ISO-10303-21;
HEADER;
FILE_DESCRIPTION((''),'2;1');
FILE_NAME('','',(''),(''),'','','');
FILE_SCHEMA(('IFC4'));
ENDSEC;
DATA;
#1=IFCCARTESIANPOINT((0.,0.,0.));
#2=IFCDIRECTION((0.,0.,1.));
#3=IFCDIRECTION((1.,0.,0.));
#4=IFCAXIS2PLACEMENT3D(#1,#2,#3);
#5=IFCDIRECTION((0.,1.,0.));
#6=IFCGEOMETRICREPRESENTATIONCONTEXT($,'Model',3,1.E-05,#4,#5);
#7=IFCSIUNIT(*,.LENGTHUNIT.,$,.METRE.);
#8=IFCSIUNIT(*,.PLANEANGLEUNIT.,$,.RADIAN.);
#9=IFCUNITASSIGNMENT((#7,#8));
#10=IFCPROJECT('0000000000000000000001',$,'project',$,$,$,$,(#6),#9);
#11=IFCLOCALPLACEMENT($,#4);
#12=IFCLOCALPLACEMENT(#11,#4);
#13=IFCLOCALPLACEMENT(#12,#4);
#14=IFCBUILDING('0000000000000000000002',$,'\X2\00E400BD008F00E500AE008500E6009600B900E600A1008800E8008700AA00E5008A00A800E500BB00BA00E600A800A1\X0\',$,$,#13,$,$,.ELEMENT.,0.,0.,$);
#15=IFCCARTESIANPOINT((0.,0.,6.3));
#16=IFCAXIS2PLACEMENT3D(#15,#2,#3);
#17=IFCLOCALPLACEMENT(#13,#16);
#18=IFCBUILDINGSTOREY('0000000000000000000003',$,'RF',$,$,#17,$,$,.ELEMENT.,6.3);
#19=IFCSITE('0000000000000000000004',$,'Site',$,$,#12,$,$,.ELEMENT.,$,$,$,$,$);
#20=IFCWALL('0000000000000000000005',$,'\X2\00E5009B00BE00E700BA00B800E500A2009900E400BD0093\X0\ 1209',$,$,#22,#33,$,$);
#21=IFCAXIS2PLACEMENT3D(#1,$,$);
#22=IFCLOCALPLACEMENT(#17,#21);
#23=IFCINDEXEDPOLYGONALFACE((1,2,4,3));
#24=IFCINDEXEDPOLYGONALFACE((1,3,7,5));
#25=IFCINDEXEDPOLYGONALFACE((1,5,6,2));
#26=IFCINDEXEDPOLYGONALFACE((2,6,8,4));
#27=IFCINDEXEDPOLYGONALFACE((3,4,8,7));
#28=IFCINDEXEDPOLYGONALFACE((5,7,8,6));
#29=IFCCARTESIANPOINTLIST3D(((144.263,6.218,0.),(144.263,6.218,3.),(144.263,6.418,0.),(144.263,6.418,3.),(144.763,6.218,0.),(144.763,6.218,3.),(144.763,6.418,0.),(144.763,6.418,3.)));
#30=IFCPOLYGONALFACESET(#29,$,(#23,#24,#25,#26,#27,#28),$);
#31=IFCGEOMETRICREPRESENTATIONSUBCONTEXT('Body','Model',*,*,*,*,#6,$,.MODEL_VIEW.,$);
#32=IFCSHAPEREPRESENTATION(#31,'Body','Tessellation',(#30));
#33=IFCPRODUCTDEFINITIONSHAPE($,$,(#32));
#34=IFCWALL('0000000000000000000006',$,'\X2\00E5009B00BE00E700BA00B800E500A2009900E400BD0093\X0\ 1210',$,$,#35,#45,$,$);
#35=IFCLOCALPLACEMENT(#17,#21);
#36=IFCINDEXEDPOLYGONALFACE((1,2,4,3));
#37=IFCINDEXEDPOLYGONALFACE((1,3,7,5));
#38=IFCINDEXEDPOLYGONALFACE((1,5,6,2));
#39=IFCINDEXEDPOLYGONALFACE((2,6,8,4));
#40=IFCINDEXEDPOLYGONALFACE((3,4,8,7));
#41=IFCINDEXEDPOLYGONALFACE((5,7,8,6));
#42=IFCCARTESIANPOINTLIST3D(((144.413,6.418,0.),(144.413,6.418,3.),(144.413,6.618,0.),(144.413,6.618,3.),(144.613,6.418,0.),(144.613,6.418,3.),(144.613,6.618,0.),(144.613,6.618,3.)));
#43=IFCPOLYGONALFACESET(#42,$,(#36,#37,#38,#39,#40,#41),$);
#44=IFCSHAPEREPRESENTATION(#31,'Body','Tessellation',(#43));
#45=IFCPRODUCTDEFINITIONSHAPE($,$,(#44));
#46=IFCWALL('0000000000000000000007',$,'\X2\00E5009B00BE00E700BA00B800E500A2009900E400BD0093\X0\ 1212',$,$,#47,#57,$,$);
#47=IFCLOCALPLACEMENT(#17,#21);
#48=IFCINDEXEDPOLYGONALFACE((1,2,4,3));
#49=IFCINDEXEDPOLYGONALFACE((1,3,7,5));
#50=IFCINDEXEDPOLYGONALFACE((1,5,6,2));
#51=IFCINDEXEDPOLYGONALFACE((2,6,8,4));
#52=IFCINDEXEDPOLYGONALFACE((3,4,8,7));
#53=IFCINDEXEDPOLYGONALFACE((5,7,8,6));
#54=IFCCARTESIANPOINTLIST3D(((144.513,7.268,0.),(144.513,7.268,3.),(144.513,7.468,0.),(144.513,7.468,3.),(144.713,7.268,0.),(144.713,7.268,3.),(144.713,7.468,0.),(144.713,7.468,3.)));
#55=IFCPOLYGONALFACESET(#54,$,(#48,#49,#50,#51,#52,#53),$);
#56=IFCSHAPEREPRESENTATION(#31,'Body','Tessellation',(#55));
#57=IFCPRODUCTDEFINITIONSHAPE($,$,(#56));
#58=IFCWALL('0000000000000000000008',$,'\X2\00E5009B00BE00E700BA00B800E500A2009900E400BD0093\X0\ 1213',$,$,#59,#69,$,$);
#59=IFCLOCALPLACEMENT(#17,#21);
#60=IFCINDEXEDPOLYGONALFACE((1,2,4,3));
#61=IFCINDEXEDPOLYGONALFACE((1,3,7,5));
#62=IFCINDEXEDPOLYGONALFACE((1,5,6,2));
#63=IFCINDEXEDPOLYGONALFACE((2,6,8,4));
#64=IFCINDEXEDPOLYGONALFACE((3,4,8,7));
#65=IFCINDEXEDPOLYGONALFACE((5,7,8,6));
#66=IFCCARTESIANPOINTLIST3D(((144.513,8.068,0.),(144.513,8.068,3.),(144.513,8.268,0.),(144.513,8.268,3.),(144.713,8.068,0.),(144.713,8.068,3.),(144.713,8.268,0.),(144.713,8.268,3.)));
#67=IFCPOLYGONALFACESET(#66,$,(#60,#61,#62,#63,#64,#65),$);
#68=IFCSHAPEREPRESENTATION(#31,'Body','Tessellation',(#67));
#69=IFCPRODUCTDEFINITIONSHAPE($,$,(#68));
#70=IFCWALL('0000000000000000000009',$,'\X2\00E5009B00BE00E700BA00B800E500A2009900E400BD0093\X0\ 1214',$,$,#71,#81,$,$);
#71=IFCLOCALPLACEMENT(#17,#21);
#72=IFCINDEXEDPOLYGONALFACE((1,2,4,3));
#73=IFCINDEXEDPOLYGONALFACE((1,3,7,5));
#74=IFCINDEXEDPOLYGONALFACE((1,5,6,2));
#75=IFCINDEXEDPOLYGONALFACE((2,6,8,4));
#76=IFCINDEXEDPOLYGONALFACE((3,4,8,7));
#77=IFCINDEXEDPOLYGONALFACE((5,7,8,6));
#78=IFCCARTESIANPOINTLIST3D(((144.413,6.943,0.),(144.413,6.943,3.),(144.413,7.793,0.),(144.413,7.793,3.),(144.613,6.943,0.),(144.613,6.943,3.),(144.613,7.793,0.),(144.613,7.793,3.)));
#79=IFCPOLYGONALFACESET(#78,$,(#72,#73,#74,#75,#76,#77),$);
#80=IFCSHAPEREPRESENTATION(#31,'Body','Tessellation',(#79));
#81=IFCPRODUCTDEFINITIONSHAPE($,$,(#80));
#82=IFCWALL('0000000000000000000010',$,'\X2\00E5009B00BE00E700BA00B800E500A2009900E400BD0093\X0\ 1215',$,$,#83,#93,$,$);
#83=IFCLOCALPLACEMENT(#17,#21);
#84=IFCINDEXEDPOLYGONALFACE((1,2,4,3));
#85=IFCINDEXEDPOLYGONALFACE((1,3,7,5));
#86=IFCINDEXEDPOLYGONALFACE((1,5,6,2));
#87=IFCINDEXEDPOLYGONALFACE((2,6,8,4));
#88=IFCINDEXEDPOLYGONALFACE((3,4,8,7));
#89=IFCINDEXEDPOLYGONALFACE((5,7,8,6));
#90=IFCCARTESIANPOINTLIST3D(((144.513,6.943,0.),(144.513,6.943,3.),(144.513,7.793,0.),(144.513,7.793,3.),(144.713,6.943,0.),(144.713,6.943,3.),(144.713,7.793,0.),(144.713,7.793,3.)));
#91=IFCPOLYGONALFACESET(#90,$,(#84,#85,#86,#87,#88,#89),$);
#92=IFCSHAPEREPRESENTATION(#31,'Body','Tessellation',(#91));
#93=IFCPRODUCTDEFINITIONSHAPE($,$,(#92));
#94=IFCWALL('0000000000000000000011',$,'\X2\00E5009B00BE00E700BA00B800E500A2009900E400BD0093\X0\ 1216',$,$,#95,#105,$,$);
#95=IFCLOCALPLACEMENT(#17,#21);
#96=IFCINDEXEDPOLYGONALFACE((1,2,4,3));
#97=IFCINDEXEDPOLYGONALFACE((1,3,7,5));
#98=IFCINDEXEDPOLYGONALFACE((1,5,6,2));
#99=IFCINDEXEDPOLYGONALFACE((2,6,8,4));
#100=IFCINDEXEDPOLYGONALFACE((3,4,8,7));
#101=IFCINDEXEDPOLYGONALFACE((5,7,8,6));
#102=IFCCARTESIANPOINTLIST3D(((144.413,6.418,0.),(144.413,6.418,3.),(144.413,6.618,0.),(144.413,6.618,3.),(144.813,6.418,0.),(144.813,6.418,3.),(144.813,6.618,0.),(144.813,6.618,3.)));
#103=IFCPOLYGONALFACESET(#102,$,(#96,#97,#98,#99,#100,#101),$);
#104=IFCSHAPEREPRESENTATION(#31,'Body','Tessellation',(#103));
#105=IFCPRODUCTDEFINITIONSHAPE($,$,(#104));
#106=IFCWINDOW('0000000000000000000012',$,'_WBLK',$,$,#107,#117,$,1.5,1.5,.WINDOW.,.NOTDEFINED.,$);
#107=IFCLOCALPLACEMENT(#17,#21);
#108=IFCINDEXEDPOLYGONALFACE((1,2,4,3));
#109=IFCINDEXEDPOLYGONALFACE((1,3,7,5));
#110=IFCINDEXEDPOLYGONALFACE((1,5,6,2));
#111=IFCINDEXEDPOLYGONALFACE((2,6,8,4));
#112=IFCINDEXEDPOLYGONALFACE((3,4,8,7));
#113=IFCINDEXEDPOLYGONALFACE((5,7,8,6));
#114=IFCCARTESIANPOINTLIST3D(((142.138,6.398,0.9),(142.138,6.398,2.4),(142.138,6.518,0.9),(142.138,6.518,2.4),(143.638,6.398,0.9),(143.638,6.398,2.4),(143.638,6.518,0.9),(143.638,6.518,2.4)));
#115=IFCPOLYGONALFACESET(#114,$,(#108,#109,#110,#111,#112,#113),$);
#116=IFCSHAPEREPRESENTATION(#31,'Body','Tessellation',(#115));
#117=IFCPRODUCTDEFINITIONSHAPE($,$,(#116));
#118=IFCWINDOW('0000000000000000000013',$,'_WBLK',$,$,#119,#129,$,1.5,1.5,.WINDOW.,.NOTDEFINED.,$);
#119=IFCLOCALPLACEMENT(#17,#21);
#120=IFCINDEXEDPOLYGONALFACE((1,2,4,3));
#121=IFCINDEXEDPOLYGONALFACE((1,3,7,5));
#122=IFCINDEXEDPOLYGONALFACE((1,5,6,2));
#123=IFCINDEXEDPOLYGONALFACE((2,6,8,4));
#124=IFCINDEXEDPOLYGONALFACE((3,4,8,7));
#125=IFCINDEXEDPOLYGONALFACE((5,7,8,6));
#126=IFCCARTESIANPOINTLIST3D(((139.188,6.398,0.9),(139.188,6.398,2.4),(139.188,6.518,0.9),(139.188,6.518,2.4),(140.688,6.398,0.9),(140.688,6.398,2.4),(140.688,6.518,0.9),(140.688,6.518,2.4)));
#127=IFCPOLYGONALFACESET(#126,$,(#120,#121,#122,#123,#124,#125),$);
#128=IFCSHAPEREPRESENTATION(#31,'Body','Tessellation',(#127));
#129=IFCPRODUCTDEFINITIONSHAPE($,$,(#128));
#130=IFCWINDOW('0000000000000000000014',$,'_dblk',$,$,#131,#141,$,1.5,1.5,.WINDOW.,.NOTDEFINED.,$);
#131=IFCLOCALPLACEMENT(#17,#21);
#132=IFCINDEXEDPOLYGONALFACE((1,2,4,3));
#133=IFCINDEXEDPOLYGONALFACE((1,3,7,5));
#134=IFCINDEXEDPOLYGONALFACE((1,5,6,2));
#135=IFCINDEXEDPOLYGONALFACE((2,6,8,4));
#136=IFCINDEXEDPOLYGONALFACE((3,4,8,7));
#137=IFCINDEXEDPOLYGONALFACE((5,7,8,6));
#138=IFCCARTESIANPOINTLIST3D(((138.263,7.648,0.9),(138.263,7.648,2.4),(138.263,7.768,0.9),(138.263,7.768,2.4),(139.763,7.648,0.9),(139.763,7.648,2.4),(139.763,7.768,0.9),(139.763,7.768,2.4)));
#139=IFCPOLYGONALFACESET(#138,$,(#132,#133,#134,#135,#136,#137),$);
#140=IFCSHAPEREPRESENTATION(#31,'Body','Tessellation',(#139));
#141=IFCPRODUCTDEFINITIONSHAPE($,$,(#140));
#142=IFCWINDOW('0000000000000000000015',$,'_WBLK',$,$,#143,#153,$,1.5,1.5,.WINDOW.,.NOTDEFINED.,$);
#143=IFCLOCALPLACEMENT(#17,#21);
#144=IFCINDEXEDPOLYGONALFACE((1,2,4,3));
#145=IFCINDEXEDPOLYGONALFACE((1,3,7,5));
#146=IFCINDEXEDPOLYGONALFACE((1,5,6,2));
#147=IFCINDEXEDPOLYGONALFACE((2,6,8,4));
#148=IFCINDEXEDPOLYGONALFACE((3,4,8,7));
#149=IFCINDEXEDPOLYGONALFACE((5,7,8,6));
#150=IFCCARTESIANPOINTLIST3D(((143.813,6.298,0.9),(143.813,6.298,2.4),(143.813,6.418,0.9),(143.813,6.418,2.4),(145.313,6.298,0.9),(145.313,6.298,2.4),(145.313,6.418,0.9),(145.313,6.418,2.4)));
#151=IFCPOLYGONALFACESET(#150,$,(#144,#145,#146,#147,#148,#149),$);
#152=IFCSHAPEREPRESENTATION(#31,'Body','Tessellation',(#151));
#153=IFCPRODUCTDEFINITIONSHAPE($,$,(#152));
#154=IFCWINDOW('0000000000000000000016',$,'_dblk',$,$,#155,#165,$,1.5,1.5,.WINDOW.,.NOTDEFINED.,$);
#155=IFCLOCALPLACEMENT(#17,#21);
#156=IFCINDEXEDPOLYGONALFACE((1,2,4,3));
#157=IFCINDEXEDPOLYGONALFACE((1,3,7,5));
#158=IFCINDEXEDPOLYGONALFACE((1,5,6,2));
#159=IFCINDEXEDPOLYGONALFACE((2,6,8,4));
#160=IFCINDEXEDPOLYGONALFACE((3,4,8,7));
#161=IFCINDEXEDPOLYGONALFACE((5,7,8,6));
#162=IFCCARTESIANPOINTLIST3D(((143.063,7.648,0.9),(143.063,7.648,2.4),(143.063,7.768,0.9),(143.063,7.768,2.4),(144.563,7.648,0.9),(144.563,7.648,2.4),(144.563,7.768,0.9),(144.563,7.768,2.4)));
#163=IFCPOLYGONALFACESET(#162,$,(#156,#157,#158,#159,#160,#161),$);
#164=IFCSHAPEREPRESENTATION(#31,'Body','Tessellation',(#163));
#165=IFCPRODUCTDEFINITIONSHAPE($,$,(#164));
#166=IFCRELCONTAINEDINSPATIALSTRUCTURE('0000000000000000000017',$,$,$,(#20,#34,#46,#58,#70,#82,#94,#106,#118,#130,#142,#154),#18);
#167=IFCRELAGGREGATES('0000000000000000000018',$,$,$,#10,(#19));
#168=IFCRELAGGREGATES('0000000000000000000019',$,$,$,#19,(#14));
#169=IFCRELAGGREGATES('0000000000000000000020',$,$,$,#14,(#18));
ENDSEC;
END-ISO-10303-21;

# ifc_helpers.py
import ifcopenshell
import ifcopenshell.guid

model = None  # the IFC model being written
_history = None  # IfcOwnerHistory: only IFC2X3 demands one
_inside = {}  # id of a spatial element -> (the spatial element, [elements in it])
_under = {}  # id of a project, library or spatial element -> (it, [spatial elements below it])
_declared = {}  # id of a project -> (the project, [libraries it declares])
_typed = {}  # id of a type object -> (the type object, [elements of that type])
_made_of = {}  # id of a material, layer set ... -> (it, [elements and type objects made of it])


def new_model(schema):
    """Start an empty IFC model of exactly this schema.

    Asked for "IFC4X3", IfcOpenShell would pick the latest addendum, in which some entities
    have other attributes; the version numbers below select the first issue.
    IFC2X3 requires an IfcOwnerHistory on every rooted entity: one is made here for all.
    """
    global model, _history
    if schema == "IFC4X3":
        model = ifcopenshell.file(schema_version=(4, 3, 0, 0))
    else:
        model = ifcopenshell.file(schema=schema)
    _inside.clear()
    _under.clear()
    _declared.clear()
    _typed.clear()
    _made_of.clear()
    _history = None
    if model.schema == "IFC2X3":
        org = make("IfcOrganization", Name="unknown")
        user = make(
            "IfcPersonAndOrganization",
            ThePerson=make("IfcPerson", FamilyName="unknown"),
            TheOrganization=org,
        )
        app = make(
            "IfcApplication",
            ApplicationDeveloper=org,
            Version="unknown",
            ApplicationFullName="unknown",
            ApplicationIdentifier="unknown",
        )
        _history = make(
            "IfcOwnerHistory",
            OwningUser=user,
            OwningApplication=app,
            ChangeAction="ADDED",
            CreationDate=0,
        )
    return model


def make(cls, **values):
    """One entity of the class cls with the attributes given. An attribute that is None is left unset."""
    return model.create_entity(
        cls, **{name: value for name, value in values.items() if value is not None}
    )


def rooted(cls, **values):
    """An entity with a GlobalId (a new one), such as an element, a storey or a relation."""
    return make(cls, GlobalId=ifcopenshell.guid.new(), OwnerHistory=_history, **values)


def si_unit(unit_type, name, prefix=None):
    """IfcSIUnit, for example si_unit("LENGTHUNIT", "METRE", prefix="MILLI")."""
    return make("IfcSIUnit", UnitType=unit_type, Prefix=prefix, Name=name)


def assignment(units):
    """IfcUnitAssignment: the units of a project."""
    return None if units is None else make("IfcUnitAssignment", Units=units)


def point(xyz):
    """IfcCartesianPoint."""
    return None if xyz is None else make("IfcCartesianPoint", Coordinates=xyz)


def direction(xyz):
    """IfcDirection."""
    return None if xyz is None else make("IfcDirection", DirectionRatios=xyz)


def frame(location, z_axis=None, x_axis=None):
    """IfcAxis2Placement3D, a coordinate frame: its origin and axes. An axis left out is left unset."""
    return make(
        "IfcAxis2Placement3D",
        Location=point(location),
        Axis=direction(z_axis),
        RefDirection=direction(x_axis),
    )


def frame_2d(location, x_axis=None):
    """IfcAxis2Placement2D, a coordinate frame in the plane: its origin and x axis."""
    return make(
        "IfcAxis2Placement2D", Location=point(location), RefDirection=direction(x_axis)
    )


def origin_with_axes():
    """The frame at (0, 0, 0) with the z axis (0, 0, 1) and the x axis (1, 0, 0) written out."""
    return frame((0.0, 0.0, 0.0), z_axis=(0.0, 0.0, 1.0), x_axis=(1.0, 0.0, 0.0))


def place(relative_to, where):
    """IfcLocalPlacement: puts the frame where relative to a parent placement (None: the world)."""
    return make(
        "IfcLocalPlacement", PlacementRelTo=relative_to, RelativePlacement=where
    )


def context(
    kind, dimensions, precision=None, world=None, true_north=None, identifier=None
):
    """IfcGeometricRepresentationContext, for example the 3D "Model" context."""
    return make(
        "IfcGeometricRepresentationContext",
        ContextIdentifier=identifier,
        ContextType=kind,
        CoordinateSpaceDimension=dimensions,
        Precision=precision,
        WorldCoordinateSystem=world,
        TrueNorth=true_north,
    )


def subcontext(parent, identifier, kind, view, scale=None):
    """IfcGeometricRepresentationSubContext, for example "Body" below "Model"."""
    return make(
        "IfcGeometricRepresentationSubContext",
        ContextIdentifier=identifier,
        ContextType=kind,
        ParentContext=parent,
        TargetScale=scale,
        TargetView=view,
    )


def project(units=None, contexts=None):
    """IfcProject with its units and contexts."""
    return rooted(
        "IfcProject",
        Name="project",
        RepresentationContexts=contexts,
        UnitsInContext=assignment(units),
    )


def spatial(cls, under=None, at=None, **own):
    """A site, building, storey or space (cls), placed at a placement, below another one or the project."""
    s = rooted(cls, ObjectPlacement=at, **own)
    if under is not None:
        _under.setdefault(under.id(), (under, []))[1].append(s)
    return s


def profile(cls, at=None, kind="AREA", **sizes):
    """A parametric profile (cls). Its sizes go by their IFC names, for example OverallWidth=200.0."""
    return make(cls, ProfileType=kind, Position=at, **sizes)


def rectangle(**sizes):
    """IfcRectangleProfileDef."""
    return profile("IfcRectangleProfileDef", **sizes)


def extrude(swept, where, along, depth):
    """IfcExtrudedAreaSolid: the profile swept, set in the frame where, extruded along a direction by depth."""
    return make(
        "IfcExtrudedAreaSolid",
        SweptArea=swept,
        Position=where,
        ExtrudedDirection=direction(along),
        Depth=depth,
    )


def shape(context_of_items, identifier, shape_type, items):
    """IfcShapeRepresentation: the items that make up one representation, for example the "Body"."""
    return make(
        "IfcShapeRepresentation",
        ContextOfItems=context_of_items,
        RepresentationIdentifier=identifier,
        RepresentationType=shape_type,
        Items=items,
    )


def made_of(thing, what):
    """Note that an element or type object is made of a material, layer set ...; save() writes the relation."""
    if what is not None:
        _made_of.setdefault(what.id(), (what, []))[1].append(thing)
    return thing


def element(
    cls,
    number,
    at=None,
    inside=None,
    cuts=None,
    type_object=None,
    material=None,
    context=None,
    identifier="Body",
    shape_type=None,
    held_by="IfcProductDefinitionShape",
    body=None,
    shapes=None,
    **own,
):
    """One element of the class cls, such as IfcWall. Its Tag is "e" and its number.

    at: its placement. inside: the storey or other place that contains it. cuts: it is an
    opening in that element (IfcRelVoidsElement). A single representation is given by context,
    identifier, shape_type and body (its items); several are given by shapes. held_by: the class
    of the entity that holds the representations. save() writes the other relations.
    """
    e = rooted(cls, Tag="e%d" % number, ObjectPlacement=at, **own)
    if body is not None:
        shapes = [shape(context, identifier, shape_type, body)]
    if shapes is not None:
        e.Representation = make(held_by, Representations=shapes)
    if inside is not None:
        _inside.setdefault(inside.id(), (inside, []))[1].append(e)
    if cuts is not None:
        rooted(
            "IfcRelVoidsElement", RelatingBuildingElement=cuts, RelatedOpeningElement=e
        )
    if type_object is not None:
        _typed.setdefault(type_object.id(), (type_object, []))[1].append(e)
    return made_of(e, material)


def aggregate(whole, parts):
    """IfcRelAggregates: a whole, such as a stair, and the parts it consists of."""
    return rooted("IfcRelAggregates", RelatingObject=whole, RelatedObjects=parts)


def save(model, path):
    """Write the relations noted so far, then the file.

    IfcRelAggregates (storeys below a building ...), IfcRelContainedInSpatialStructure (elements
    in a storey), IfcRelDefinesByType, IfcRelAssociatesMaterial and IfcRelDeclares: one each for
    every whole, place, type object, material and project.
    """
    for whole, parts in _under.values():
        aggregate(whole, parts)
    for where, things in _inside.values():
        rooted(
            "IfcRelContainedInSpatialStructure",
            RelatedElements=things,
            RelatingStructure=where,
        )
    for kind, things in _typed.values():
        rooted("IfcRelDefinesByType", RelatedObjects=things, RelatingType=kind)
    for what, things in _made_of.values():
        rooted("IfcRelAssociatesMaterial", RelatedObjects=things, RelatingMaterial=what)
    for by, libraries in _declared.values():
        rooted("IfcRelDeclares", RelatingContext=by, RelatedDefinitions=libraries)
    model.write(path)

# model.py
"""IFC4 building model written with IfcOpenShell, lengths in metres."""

from ifc_helpers import new_model, si_unit, direction, frame, frame_2d, origin_with_axes, place, context, subcontext, project, spatial, rectangle, extrude, element, save


model = new_model("IFC4")

# Units and contexts
model_context = context("Model", 3, precision=1e-05, world=origin_with_axes(), true_north=direction((0.0, 1.0, 0.0)))
body_context = subcontext(model_context, "Body", "Model", "MODEL_VIEW")
ifc_project = project(units=[si_unit("LENGTHUNIT", "METRE"), si_unit("PLANEANGLEUNIT", "RADIAN")], contexts=[model_context])

# Site, building, storey
placement = place(None, origin_with_axes())
site_placement = place(placement, origin_with_axes())
site = spatial("IfcSite", under=ifc_project, at=site_placement, Name="Site", CompositionType="ELEMENT")
building_placement = place(site_placement, origin_with_axes())
building = spatial("IfcBuilding", under=site, at=building_placement, Name="ä½\u008få®\u0085æ\u0096¹æ¡\u0088è\u0087ªå\u008a¨å»ºæ¨¡", CompositionType="ELEMENT", ElevationOfRefHeight=0.0, ElevationOfTerrain=0.0)
storey_placement = place(building_placement, frame((0.0, 0.0, 6.3), z_axis=(0.0, 0.0, 1.0), x_axis=(1.0, 0.0, 0.0)))
storey = spatial("IfcBuildingStorey", under=building, at=storey_placement, Name="RF", CompositionType="ELEMENT", Elevation=6.3)

# Walls
for number, where, z_axis, x_axis, name in (
    (1, (144.513, 6.318, 0.0), (0.0, 0.0, 1.0), (1.0, 0.0, 0.0), "å\u009b¾çº¸å¢\u0099ä½\u0093 1209"),
):
    element("IfcWall", number, at=place(storey_placement, frame(where, z_axis=z_axis, x_axis=x_axis)), inside=storey, Name=name, context=body_context, shape_type="SweptSolid", body=[
        extrude(rectangle(XDim=0.5, YDim=0.2, at=frame_2d((0.0, 0.0), x_axis=(1.0, 0.0, 0.0))), frame((0.0, 0.0, 0.0), z_axis=(0.0, 0.0, 1.0)), (0.0, 0.0, 1.0), 3.0),
    ])
for number, where, z_axis, x_axis, name in (
    (2, (144.513, 6.518, 0.0), (0.0, 0.0, 1.0), (0.0, -1.0, 0.0), "å\u009b¾çº¸å¢\u0099ä½\u0093 1210"),
    (3, (144.613, 7.368, 0.0), (0.0, 0.0, 1.0), (-1.0, 0.0, 0.0), "å\u009b¾çº¸å¢\u0099ä½\u0093 1212"),
    (4, (144.613, 8.168, 0.0), (0.0, 0.0, 1.0), (-1.0, 0.0, 0.0), "å\u009b¾çº¸å¢\u0099ä½\u0093 1213"),
):
    element("IfcWall", number, at=place(storey_placement, frame(where, z_axis=z_axis, x_axis=x_axis)), inside=storey, Name=name, context=body_context, shape_type="SweptSolid", body=[
        extrude(rectangle(XDim=0.2, YDim=0.2, at=frame_2d((0.0, 0.0), x_axis=(1.0, 0.0, 0.0))), frame((0.0, 0.0, 0.0), z_axis=(0.0, 0.0, 1.0)), (0.0, 0.0, 1.0), 3.0),
    ])
for number, where, z_axis, x_axis, name in (
    (5, (144.513, 7.368, 0.0), (0.0, 0.0, 1.0), (0.0, -1.0, 0.0), "å\u009b¾çº¸å¢\u0099ä½\u0093 1214"),
    (6, (144.613, 7.368, 0.0), (0.0, 0.0, 1.0), (0.0, -1.0, 0.0), "å\u009b¾çº¸å¢\u0099ä½\u0093 1215"),
):
    element("IfcWall", number, at=place(storey_placement, frame(where, z_axis=z_axis, x_axis=x_axis)), inside=storey, Name=name, context=body_context, shape_type="SweptSolid", body=[
        extrude(rectangle(XDim=0.85, YDim=0.2, at=frame_2d((0.0, 0.0), x_axis=(1.0, 0.0, 0.0))), frame((0.0, 0.0, 0.0), z_axis=(0.0, 0.0, 1.0)), (0.0, 0.0, 1.0), 3.0),
    ])
wall_1_placement = place(storey_placement, frame((144.613, 6.518, 0.0), z_axis=(0.0, 0.0, 1.0), x_axis=(1.0, 0.0, 0.0)))
element("IfcWall", 7, at=wall_1_placement, inside=storey, Name="å\u009b¾çº¸å¢\u0099ä½\u0093 1216", context=body_context, shape_type="SweptSolid", body=[
    extrude(rectangle(XDim=0.4, YDim=0.2, at=frame_2d((0.0, 0.0), x_axis=(1.0, 0.0, 0.0))), frame((0.0, 0.0, 0.0), z_axis=(0.0, 0.0, 1.0)), (0.0, 0.0, 1.0), 3.0),
])

# Windows
for number, where, z_axis, x_axis, name in (
    (8, (142.888, 6.458, 0.9), (0.0, 0.0, 1.0), (1.0, 0.0, 0.0), "_WBLK"),
    (9, (139.938, 6.458, 0.9), (0.0, 0.0, 1.0), (1.0, 0.0, 0.0), "_WBLK"),
    (10, (139.013, 7.708, 0.9), (0.0, 0.0, 1.0), (1.0, 0.0, 0.0), "_dblk"),
    (11, (144.563, 6.358, 0.9), (0.0, 0.0, 1.0), (1.0, 0.0, 0.0), "_WBLK"),
    (12, (143.813, 7.708, 0.9), (0.0, 0.0, 1.0), (1.0, 0.0, 0.0), "_dblk"),
):
    element("IfcWindow", number, at=place(storey_placement, frame(where, z_axis=z_axis, x_axis=x_axis)), inside=storey, Name=name, OverallHeight=1.5, OverallWidth=1.5, PartitioningType="NOTDEFINED", PredefinedType="WINDOW", context=body_context, shape_type="SweptSolid", body=[
        extrude(rectangle(XDim=1.5, YDim=0.12, at=frame_2d((0.0, 0.0), x_axis=(1.0, 0.0, 0.0))), frame((0.0, 0.0, 0.0), z_axis=(0.0, 0.0, 1.0)), (0.0, 0.0, 1.0), 1.5),
    ])

save(model, "model.ifc")
